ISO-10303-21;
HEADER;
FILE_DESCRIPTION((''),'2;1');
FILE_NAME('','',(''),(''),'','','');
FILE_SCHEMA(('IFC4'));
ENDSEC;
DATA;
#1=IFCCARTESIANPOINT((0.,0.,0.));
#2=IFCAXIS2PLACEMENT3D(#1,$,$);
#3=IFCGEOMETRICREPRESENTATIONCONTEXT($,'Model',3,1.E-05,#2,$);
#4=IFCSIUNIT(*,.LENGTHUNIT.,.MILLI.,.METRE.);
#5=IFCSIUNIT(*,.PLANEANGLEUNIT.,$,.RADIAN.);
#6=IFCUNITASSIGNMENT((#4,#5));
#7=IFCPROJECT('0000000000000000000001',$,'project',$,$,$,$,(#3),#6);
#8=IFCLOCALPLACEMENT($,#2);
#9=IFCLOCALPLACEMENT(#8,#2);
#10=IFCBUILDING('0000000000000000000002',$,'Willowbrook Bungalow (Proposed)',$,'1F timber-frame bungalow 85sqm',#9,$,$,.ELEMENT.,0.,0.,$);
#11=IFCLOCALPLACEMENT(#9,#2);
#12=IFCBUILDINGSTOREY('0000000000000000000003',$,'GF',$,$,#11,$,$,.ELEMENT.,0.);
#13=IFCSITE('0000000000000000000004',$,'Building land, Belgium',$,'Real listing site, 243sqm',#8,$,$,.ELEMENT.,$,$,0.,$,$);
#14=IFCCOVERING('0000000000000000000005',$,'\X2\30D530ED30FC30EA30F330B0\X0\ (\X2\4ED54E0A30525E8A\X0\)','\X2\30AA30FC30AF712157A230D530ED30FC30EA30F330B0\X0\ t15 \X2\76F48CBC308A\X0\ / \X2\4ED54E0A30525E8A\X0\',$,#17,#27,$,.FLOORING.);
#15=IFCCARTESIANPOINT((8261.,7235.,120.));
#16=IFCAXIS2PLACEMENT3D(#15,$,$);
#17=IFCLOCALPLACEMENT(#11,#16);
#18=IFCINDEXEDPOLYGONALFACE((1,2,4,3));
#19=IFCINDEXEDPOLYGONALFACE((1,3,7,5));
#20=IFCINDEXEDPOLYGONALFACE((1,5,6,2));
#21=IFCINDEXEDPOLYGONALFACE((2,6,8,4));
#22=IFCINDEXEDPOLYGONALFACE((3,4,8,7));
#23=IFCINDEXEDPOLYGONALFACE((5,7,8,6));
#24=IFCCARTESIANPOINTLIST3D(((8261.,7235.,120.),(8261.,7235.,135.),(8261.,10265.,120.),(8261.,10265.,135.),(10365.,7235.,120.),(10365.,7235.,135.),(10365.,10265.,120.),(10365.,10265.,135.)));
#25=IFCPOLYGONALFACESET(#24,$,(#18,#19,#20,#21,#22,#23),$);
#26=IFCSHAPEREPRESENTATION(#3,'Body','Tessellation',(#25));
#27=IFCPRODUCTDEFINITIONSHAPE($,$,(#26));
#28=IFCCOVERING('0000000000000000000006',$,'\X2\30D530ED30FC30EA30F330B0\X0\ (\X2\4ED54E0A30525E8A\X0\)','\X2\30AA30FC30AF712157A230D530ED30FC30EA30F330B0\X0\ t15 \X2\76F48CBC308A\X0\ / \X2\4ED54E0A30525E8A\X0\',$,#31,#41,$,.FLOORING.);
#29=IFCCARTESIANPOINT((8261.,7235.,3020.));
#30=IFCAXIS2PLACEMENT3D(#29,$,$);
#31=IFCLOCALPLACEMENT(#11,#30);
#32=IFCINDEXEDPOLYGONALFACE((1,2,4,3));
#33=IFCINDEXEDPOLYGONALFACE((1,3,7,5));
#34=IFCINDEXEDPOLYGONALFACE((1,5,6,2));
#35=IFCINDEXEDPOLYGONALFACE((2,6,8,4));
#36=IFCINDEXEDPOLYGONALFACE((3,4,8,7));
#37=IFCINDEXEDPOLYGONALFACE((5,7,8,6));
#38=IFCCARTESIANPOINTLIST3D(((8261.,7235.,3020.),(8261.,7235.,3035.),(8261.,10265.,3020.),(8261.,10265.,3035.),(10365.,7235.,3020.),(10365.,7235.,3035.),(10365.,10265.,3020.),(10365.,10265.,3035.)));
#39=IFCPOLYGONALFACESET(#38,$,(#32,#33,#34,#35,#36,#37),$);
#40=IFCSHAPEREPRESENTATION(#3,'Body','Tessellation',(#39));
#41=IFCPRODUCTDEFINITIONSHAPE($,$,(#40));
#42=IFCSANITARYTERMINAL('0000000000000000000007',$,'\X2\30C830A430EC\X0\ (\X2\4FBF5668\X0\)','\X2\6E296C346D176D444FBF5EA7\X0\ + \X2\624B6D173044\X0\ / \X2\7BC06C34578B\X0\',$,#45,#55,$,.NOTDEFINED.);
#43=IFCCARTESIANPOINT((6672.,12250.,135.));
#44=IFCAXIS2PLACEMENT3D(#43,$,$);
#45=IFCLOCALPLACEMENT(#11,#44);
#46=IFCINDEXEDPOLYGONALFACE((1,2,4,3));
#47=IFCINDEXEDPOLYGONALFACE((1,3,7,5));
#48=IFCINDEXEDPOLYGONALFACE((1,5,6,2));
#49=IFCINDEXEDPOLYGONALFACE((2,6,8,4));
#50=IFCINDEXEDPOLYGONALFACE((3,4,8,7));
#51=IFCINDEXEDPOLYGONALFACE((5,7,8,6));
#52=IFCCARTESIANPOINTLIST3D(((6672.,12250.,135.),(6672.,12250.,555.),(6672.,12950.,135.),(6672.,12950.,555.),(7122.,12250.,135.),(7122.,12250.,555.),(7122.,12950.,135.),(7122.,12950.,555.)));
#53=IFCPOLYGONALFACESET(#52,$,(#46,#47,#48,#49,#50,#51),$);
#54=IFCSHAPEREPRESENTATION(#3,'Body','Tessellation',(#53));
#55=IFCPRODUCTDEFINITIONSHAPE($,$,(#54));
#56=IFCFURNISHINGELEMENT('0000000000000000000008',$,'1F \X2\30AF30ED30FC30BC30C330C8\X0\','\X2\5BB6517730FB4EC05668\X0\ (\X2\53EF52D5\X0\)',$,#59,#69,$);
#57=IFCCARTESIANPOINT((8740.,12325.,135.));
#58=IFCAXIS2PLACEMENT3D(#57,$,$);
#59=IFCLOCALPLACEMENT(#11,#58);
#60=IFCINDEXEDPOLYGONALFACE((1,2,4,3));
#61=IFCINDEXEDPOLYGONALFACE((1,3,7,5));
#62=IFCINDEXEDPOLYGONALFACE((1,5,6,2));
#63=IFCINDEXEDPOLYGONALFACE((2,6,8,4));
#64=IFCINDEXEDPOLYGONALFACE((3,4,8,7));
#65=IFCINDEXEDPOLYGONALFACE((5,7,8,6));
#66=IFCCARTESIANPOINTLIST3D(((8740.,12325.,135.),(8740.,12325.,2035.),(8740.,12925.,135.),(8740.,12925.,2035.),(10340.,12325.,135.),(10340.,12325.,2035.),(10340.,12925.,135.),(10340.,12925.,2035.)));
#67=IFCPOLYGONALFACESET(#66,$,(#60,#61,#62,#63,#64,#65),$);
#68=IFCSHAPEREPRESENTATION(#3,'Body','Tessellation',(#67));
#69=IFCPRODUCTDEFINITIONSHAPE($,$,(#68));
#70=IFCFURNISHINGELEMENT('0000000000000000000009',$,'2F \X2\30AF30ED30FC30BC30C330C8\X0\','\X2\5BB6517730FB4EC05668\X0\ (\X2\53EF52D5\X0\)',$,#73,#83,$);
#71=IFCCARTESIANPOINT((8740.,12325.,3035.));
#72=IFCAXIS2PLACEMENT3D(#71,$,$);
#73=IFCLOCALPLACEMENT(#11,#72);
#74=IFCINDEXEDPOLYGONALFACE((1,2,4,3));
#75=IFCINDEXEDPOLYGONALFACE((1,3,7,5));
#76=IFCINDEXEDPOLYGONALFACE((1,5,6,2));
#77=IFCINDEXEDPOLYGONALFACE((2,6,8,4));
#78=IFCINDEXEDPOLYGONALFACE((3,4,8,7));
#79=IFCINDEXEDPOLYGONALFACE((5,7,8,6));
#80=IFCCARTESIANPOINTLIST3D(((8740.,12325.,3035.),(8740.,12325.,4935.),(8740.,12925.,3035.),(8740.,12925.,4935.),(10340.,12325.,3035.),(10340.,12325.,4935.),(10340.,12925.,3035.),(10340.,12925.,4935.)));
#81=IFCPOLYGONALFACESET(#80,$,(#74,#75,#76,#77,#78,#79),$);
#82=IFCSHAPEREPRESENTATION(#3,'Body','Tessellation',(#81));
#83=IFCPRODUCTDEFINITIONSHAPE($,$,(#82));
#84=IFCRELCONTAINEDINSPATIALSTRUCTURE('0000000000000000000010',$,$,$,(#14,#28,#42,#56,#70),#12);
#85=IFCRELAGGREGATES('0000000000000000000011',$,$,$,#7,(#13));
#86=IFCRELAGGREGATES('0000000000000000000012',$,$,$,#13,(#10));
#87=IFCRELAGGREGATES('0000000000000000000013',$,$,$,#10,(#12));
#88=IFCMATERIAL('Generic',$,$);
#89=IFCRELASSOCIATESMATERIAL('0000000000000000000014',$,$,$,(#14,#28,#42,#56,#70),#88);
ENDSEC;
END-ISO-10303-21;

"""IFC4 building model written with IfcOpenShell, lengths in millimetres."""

from ifc_helpers import new_model, si_unit, frame, frame_2d, origin, place, context, project, spatial, rectangle, extrude, material, element, save


model = new_model("IFC4")

# Units and contexts
model_context = context("Model", 3, precision=1e-05, world=origin())
ifc_project = project(units=[si_unit("LENGTHUNIT", "METRE", prefix="MILLI"), si_unit("PLANEANGLEUNIT", "RADIAN")], contexts=[model_context])

# Site, building, storey
site_placement = place(None, origin())
site = spatial("IfcSite", under=ifc_project, at=site_placement, Name="Building land, Belgium", ObjectType="Real listing site, 243sqm", CompositionType="ELEMENT", RefElevation=0.0)
building_placement = place(site_placement, origin())
building = spatial("IfcBuilding", under=site, at=building_placement, Name="Willowbrook Bungalow (Proposed)", ObjectType="1F timber-frame bungalow 85sqm", CompositionType="ELEMENT", ElevationOfRefHeight=0.0, ElevationOfTerrain=0.0)
storey_placement = place(building_placement, origin())
storey = spatial("IfcBuildingStorey", under=building, at=storey_placement, Name="GF", CompositionType="ELEMENT", Elevation=0.0)

# Shared definitions
ifc_material_1 = material(Name="Generic")

# Coverings
covering_1_placement = place(storey_placement, frame((8261.0, 7235.0, 120.0)))
element("IfcCovering", 1, at=covering_1_placement, inside=storey, material=ifc_material_1, Name="フローリング (仕上げ床)", Description="オーク無垢フローリング t15 直貼り / 仕上げ床", PredefinedType="FLOORING", context=model_context, shape_type="SweptSolid", body=[
    extrude(rectangle(XDim=2104.0, YDim=3030.0, at=frame_2d((1052.0, 1515.0))), frame((8261.0, 7235.0, 120.0)), (0.0, 0.0, 1.0), 15.0),
])
covering_2_placement = place(storey_placement, frame((8261.0, 7235.0, 3020.0)))
element("IfcCovering", 2, at=covering_2_placement, inside=storey, material=ifc_material_1, Name="フローリング (仕上げ床)", Description="オーク無垢フローリング t15 直貼り / 仕上げ床", PredefinedType="FLOORING", context=model_context, shape_type="SweptSolid", body=[
    extrude(rectangle(XDim=2104.0, YDim=3030.0, at=frame_2d((1052.0, 1515.0))), frame((8261.0, 7235.0, 3020.0)), (0.0, 0.0, 1.0), 15.0),
])

# Sanitary terminal
sanitary_terminal_placement = place(storey_placement, frame((6672.0, 12250.0, 135.0)))
element("IfcSanitaryTerminal", 3, at=sanitary_terminal_placement, inside=storey, material=ifc_material_1, Name="トイレ (便器)", Description="温水洗浄便座 + 手洗い / 節水型", PredefinedType="NOTDEFINED", context=model_context, shape_type="SweptSolid", body=[
    extrude(rectangle(XDim=450.0, YDim=700.0, at=frame_2d((225.0, 350.0))), frame((6672.0, 12250.0, 135.0)), (0.0, 0.0, 1.0), 420.0),
])

# Furnishing elements
furnishing_1_placement = place(storey_placement, frame((8740.0, 12325.0, 135.0)))
element("IfcFurnishingElement", 4, at=furnishing_1_placement, inside=storey, material=ifc_material_1, Name="1F クローゼット", Description="家具・什器 (可動)", context=model_context, shape_type="SweptSolid", body=[
    extrude(rectangle(XDim=1600.0, YDim=600.0, at=frame_2d((800.0, 300.0))), frame((8740.0, 12325.0, 135.0)), (0.0, 0.0, 1.0), 1900.0),
])
furnishing_2_placement = place(storey_placement, frame((8740.0, 12325.0, 3035.0)))
element("IfcFurnishingElement", 5, at=furnishing_2_placement, inside=storey, material=ifc_material_1, Name="2F クローゼット", Description="家具・什器 (可動)", context=model_context, shape_type="SweptSolid", body=[
    extrude(rectangle(XDim=1600.0, YDim=600.0, at=frame_2d((800.0, 300.0))), frame((8740.0, 12325.0, 3035.0)), (0.0, 0.0, 1.0), 1900.0),
])

save(model, "model.ifc")
